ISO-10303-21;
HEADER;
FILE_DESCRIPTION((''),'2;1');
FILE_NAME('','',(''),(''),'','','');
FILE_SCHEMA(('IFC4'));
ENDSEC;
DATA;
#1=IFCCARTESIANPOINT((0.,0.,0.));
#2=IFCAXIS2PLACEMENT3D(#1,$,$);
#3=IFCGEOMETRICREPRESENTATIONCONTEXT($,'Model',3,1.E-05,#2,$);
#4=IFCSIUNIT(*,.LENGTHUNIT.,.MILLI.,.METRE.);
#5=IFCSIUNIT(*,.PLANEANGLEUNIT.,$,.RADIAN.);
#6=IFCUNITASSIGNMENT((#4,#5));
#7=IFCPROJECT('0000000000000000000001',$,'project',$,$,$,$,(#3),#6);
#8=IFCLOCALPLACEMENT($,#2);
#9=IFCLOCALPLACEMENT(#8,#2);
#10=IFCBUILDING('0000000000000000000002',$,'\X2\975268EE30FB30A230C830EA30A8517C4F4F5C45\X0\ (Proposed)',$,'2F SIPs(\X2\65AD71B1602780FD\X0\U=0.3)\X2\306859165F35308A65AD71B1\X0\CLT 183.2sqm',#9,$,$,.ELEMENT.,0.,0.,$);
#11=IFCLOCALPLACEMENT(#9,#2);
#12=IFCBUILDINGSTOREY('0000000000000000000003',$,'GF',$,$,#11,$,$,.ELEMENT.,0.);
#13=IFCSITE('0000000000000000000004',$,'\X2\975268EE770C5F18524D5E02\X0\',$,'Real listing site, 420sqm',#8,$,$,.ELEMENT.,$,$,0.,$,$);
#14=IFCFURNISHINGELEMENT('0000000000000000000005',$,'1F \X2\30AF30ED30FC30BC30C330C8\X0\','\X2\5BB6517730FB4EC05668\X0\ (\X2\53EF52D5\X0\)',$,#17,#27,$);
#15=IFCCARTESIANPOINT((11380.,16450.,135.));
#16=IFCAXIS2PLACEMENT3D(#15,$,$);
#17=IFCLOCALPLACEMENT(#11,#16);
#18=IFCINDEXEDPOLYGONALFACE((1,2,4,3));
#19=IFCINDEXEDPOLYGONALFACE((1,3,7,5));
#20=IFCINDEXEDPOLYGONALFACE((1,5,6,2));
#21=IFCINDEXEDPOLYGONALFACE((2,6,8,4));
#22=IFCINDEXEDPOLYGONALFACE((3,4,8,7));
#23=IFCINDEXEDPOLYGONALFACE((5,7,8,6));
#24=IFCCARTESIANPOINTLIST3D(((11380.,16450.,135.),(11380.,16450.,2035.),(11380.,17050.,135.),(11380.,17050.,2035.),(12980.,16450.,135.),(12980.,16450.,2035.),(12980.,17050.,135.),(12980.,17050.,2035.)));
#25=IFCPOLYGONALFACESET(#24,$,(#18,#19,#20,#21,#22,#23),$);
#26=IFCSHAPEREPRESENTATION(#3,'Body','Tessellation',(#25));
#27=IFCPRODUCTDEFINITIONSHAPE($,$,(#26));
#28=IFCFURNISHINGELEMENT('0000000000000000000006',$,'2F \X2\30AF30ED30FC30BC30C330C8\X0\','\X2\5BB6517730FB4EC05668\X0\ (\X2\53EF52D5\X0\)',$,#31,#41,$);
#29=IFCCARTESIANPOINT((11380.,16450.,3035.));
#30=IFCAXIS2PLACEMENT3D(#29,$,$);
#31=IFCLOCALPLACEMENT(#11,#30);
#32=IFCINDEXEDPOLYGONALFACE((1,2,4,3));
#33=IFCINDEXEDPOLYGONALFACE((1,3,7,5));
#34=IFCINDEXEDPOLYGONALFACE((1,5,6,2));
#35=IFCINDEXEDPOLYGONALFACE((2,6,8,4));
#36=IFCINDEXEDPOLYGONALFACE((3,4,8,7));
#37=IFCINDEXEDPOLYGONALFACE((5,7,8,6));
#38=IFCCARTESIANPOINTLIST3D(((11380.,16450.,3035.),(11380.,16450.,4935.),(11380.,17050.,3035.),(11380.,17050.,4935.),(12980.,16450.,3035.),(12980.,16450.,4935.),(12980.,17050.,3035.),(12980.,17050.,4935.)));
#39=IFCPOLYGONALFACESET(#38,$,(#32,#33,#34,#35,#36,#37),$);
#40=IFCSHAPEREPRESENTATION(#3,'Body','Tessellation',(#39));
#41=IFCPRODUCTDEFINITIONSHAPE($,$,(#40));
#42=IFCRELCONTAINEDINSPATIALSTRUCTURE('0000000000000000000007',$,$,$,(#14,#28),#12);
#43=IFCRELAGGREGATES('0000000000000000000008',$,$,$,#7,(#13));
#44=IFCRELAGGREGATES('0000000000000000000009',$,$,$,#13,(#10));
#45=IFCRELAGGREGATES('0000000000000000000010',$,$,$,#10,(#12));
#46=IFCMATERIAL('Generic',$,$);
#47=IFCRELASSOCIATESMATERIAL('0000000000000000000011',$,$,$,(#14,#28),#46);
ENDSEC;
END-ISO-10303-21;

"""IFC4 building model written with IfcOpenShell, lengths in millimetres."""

from ifc_helpers import new_model, si_unit, frame, frame_2d, origin, place, context, project, spatial, rectangle, extrude, material, element, save


model = new_model("IFC4")

# Units and contexts
model_context = context("Model", 3, precision=1e-05, world=origin())
ifc_project = project(units=[si_unit("LENGTHUNIT", "METRE", prefix="MILLI"), si_unit("PLANEANGLEUNIT", "RADIAN")], contexts=[model_context])

# Site, building, storey
site_placement = place(None, origin())
site = spatial("IfcSite", under=ifc_project, at=site_placement, Name="青森県弘前市", ObjectType="Real listing site, 420sqm", CompositionType="ELEMENT", RefElevation=0.0)
building_placement = place(site_placement, origin())
building = spatial("IfcBuilding", under=site, at=building_placement, Name="青森・アトリエ兼住居 (Proposed)", ObjectType="2F SIPs(断熱性能U=0.3)と外張り断熱CLT 183.2sqm", CompositionType="ELEMENT", ElevationOfRefHeight=0.0, ElevationOfTerrain=0.0)
storey_placement = place(building_placement, origin())
storey = spatial("IfcBuildingStorey", under=building, at=storey_placement, Name="GF", CompositionType="ELEMENT", Elevation=0.0)

# Shared definitions
ifc_material_1 = material(Name="Generic")

# Furnishing elements
furnishing_1_placement = place(storey_placement, frame((11380.0, 16450.0, 135.0)))
element("IfcFurnishingElement", 1, at=furnishing_1_placement, inside=storey, material=ifc_material_1, Name="1F クローゼット", Description="家具・什器 (可動)", context=model_context, shape_type="SweptSolid", body=[
    extrude(rectangle(XDim=1600.0, YDim=600.0, at=frame_2d((800.0, 300.0))), frame((11380.0, 16450.0, 135.0)), (0.0, 0.0, 1.0), 1900.0),
])
furnishing_2_placement = place(storey_placement, frame((11380.0, 16450.0, 3035.0)))
element("IfcFurnishingElement", 2, at=furnishing_2_placement, inside=storey, material=ifc_material_1, Name="2F クローゼット", Description="家具・什器 (可動)", context=model_context, shape_type="SweptSolid", body=[
    extrude(rectangle(XDim=1600.0, YDim=600.0, at=frame_2d((800.0, 300.0))), frame((11380.0, 16450.0, 3035.0)), (0.0, 0.0, 1.0), 1900.0),
])

save(model, "model.ifc")
